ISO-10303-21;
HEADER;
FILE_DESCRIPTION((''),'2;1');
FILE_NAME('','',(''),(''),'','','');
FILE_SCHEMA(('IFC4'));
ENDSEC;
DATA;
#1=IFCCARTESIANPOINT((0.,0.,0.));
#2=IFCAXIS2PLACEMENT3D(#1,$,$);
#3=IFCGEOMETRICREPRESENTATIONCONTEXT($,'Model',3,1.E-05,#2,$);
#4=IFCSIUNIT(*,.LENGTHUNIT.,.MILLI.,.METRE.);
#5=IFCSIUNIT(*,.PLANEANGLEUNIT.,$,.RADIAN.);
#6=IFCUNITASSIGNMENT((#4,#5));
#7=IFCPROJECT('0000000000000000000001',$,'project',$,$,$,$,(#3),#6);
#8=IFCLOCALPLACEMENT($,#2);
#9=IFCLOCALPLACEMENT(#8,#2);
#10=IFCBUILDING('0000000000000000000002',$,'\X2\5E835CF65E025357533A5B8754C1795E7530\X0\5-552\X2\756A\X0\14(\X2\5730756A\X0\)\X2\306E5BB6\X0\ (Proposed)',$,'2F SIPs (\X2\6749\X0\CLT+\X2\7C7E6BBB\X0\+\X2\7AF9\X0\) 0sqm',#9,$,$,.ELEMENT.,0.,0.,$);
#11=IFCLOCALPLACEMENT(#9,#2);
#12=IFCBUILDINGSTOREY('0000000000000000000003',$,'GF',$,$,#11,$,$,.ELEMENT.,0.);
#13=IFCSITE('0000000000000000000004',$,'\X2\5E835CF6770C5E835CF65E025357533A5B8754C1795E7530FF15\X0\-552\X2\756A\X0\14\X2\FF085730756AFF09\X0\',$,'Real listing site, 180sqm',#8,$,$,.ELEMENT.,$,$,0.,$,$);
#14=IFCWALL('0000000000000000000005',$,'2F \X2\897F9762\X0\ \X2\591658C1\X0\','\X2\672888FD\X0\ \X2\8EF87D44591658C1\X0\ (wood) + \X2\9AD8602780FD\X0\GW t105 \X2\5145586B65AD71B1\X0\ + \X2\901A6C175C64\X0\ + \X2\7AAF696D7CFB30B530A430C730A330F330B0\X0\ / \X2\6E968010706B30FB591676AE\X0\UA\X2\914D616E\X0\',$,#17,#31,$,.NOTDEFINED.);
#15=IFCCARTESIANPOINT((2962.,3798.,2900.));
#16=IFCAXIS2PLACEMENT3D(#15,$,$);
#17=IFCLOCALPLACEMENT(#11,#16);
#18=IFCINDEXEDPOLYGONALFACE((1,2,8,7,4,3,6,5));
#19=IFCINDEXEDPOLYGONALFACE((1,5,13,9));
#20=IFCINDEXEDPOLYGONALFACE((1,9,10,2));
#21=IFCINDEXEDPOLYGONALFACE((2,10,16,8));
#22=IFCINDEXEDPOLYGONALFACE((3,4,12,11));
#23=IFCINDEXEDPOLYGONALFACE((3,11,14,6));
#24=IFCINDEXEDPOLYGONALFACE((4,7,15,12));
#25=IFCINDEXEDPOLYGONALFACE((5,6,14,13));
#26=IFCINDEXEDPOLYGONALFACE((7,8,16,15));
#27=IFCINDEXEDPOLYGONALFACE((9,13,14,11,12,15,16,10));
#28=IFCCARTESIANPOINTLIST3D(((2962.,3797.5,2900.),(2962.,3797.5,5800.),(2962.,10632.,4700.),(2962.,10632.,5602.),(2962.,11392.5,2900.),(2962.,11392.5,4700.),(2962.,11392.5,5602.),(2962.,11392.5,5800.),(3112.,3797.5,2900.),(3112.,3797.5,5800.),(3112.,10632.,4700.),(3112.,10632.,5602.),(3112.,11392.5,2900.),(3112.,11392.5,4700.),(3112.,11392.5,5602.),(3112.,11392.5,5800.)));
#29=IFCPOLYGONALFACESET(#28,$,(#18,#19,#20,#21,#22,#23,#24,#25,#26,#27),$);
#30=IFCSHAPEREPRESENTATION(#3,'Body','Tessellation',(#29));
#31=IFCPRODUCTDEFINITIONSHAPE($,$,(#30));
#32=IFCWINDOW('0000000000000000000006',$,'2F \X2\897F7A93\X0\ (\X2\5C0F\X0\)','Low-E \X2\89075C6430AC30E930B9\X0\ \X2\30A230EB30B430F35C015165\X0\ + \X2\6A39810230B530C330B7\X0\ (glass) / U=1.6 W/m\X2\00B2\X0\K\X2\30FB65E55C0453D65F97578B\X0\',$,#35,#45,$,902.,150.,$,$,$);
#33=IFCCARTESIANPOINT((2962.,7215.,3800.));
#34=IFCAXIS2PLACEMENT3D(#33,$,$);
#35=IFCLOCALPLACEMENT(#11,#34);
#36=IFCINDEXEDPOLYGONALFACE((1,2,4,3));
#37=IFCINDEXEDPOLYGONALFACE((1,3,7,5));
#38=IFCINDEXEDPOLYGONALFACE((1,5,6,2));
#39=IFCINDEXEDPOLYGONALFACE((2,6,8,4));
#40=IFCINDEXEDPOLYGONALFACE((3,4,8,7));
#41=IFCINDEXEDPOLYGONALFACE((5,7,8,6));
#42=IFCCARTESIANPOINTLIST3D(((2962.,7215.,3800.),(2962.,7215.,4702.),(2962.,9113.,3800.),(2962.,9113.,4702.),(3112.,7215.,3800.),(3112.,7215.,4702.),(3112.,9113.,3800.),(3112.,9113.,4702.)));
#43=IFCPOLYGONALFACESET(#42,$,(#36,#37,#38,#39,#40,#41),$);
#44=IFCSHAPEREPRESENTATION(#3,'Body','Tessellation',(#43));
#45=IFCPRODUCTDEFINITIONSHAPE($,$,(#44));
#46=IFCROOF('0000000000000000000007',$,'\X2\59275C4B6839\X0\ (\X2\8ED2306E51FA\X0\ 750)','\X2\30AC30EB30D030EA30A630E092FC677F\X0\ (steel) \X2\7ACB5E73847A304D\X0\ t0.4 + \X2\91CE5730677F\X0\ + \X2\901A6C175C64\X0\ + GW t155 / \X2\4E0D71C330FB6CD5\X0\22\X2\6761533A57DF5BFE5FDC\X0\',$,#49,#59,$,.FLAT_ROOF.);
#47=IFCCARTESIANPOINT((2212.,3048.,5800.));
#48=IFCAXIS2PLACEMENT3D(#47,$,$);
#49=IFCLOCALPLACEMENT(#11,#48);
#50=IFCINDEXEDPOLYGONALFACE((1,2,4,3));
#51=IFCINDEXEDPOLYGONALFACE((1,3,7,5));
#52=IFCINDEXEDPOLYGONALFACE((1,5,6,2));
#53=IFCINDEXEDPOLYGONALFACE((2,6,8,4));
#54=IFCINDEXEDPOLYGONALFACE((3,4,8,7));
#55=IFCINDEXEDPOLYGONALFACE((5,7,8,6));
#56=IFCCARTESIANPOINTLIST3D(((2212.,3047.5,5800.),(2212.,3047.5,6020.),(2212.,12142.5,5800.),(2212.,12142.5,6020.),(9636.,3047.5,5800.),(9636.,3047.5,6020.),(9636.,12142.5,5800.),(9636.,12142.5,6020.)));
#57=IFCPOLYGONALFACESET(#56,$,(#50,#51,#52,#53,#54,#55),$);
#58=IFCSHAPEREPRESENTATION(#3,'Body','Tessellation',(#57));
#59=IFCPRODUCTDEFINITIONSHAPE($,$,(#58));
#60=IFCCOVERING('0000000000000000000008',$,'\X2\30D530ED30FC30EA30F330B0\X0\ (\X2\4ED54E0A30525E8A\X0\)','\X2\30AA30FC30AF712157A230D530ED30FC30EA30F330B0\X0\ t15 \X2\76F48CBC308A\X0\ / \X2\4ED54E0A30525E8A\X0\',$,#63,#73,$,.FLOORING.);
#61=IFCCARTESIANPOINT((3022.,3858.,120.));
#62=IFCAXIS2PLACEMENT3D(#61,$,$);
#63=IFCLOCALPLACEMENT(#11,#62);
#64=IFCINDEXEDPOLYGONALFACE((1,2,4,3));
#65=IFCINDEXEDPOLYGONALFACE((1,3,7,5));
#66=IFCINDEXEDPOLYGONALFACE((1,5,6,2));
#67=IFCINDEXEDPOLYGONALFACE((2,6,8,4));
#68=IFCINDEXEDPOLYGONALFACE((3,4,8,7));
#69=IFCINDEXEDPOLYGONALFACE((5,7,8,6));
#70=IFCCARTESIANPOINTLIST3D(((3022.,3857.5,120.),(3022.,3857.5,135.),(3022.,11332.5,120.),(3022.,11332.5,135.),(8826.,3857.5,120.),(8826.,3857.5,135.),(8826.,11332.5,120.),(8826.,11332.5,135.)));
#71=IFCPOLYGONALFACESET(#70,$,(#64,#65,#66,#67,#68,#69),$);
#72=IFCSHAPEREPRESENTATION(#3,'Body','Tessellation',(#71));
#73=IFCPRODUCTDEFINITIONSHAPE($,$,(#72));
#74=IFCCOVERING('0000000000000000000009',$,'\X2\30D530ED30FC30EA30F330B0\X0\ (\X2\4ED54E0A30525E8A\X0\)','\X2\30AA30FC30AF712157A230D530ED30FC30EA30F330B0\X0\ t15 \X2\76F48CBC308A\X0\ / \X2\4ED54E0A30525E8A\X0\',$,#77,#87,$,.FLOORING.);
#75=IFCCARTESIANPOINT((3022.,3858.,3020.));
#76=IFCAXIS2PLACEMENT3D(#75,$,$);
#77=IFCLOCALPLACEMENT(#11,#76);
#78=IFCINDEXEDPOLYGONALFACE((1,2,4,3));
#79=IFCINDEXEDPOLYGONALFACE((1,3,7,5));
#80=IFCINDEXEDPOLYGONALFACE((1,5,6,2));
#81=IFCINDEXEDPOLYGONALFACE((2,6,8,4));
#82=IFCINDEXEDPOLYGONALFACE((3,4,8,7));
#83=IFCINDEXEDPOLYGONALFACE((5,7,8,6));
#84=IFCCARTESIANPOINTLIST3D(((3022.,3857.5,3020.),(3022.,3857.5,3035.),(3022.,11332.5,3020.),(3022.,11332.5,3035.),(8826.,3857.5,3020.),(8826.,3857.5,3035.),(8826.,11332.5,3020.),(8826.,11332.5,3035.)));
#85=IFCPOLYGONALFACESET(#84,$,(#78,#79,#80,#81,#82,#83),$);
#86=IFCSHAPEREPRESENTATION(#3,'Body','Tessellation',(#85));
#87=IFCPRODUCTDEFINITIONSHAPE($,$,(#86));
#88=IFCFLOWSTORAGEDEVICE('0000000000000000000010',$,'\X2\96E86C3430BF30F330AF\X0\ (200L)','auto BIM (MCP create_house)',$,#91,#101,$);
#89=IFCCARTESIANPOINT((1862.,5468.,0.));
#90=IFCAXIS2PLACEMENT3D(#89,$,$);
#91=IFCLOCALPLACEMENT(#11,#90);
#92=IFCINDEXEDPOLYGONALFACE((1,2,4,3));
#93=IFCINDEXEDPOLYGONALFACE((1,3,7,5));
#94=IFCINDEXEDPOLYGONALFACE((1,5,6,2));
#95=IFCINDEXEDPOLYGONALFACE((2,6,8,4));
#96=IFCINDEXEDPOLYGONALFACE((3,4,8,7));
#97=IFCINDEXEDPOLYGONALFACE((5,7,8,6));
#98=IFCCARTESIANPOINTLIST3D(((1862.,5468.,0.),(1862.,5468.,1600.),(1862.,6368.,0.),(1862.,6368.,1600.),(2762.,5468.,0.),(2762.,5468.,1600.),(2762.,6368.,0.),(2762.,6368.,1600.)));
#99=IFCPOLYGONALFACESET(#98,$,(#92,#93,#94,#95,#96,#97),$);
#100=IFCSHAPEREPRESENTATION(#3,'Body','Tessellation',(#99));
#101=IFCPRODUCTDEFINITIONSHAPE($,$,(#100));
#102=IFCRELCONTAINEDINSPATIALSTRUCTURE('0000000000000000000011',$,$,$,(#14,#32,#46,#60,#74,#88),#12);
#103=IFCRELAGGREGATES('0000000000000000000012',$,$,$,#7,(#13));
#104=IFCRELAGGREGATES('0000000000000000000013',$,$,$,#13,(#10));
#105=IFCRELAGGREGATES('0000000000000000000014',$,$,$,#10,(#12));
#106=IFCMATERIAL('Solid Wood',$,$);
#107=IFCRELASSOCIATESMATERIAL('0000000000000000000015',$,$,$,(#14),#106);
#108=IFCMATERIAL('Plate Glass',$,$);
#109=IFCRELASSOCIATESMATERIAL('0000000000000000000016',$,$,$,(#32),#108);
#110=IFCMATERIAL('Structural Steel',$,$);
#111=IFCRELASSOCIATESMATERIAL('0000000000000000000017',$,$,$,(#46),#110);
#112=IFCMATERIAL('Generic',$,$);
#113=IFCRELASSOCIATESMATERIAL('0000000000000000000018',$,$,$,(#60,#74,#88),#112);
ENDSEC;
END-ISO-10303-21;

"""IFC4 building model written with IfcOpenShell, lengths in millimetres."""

from ifc_helpers import new_model, si_unit, frame, frame_2d, origin, place, context, project, spatial, rectangle, extrude, material, element, fill, save


model = new_model("IFC4")

# Units and contexts
model_context = context("Model", 3, precision=1e-05, world=origin())
ifc_project = project(units=[si_unit("LENGTHUNIT", "METRE", prefix="MILLI"), si_unit("PLANEANGLEUNIT", "RADIAN")], contexts=[model_context])

# Site, building, storey
site_placement = place(None, origin())
site = spatial("IfcSite", under=ifc_project, at=site_placement, Name="広島県広島市南区宇品神田５-552番14（地番）", ObjectType="Real listing site, 180sqm", CompositionType="ELEMENT", RefElevation=0.0)
building_placement = place(site_placement, origin())
building = spatial("IfcBuilding", under=site, at=building_placement, Name="広島市南区宇品神田5-552番14(地番)の家 (Proposed)", ObjectType="2F SIPs (杉CLT+籾殻+竹) 0sqm", CompositionType="ELEMENT", ElevationOfRefHeight=0.0, ElevationOfTerrain=0.0)
storey_placement = place(building_placement, origin())
storey = spatial("IfcBuildingStorey", under=building, at=storey_placement, Name="GF", CompositionType="ELEMENT", Elevation=0.0)

# Shared definitions
ifc_material_1 = material(Name="Solid Wood")

# Shared definitions
ifc_material_2 = material(Name="Plate Glass")

# Wall, opening, window
wall_1_placement = place(storey_placement, frame((2962.0, 3798.0, 2900.0)))
wall_1 = element("IfcWall", 1, at=wall_1_placement, inside=storey, material=ifc_material_1, Name="2F 西面 外壁", Description="木製 軸組外壁 (wood) + 高性能GW t105 充填断熱 + 通気層 + 窯業系サイディング / 準耐火・外皮UA配慮", PredefinedType="NOTDEFINED", context=model_context, shape_type="SweptSolid", body=[
    extrude(rectangle(XDim=150.0, YDim=7595.0, at=frame_2d((75.0, 3797.0))), frame((2962.0, 3798.0, 2900.0)), (0.0, 0.0, 1.0), 2900.0),
])
opening_1_placement = place(storey_placement, frame((2962.0, 7215.0, 3800.0)))
opening_1 = element("IfcOpeningElement", 2, at=opening_1_placement, cuts=wall_1, PredefinedType="NOTDEFINED", context=model_context, shape_type="SweptSolid", body=[
    extrude(rectangle(XDim=150.0, YDim=1898.0, at=frame_2d((75.0, 949.0))), frame((2962.0, 7215.0, 3800.0)), (0.0, 0.0, 1.0), 902.0),
])
window_1_placement = place(storey_placement, frame((2962.0, 7215.0, 3800.0)))
window_1 = element("IfcWindow", 3, at=window_1_placement, inside=storey, material=ifc_material_2, Name="2F 西窓 (小)", Description="Low-E 複層ガラス アルゴン封入 + 樹脂サッシ (glass) / U=1.6 W/m²K・日射取得型", OverallHeight=902.0, OverallWidth=150.0, context=model_context, shape_type="SweptSolid", body=[
    extrude(rectangle(XDim=150.0, YDim=1898.0, at=frame_2d((75.0, 949.0))), frame((2962.0, 7215.0, 3800.0)), (0.0, 0.0, 1.0), 902.0),
])
fill(opening_1, window_1)

# Roof
ifc_material_3 = material(Name="Structural Steel")
roof_placement = place(storey_placement, frame((2212.0, 3048.0, 5800.0)))
element("IfcRoof", 4, at=roof_placement, inside=storey, material=ifc_material_3, Name="大屋根 (軒の出 750)", Description="ガルバリウム鋼板 (steel) 立平葺き t0.4 + 野地板 + 通気層 + GW t155 / 不燃・法22条区域対応", PredefinedType="FLAT_ROOF", context=model_context, shape_type="SweptSolid", body=[
    extrude(rectangle(XDim=7424.0, YDim=9095.0, at=frame_2d((3712.0, 4547.0))), frame((2212.0, 3048.0, 5800.0)), (0.0, 0.0, 1.0), 220.0),
])

# Coverings
ifc_material_4 = material(Name="Generic")
covering_1_placement = place(storey_placement, frame((3022.0, 3858.0, 120.0)))
element("IfcCovering", 5, at=covering_1_placement, inside=storey, material=ifc_material_4, Name="フローリング (仕上げ床)", Description="オーク無垢フローリング t15 直貼り / 仕上げ床", PredefinedType="FLOORING", context=model_context, shape_type="SweptSolid", body=[
    extrude(rectangle(XDim=5804.0, YDim=7475.0, at=frame_2d((2902.0, 3737.0))), frame((3022.0, 3858.0, 120.0)), (0.0, 0.0, 1.0), 15.0),
])
covering_2_placement = place(storey_placement, frame((3022.0, 3858.0, 3020.0)))
element("IfcCovering", 6, at=covering_2_placement, inside=storey, material=ifc_material_4, Name="フローリング (仕上げ床)", Description="オーク無垢フローリング t15 直貼り / 仕上げ床", PredefinedType="FLOORING", context=model_context, shape_type="SweptSolid", body=[
    extrude(rectangle(XDim=5804.0, YDim=7475.0, at=frame_2d((2902.0, 3737.0))), frame((3022.0, 3858.0, 3020.0)), (0.0, 0.0, 1.0), 15.0),
])

# Flow storage device
flow_storage_device_placement = place(storey_placement, frame((1862.0, 5468.0, 0.0)))
element("IfcFlowStorageDevice", 7, at=flow_storage_device_placement, inside=storey, material=ifc_material_4, Name="雨水タンク (200L)", Description="auto BIM (MCP create_house)", context=model_context, shape_type="SweptSolid", body=[
    extrude(rectangle(XDim=900.0, YDim=900.0, at=frame_2d((450.0, 450.0))), frame((1862.0, 5468.0, 0.0)), (0.0, 0.0, 1.0), 1600.0),
])

save(model, "model.ifc")
